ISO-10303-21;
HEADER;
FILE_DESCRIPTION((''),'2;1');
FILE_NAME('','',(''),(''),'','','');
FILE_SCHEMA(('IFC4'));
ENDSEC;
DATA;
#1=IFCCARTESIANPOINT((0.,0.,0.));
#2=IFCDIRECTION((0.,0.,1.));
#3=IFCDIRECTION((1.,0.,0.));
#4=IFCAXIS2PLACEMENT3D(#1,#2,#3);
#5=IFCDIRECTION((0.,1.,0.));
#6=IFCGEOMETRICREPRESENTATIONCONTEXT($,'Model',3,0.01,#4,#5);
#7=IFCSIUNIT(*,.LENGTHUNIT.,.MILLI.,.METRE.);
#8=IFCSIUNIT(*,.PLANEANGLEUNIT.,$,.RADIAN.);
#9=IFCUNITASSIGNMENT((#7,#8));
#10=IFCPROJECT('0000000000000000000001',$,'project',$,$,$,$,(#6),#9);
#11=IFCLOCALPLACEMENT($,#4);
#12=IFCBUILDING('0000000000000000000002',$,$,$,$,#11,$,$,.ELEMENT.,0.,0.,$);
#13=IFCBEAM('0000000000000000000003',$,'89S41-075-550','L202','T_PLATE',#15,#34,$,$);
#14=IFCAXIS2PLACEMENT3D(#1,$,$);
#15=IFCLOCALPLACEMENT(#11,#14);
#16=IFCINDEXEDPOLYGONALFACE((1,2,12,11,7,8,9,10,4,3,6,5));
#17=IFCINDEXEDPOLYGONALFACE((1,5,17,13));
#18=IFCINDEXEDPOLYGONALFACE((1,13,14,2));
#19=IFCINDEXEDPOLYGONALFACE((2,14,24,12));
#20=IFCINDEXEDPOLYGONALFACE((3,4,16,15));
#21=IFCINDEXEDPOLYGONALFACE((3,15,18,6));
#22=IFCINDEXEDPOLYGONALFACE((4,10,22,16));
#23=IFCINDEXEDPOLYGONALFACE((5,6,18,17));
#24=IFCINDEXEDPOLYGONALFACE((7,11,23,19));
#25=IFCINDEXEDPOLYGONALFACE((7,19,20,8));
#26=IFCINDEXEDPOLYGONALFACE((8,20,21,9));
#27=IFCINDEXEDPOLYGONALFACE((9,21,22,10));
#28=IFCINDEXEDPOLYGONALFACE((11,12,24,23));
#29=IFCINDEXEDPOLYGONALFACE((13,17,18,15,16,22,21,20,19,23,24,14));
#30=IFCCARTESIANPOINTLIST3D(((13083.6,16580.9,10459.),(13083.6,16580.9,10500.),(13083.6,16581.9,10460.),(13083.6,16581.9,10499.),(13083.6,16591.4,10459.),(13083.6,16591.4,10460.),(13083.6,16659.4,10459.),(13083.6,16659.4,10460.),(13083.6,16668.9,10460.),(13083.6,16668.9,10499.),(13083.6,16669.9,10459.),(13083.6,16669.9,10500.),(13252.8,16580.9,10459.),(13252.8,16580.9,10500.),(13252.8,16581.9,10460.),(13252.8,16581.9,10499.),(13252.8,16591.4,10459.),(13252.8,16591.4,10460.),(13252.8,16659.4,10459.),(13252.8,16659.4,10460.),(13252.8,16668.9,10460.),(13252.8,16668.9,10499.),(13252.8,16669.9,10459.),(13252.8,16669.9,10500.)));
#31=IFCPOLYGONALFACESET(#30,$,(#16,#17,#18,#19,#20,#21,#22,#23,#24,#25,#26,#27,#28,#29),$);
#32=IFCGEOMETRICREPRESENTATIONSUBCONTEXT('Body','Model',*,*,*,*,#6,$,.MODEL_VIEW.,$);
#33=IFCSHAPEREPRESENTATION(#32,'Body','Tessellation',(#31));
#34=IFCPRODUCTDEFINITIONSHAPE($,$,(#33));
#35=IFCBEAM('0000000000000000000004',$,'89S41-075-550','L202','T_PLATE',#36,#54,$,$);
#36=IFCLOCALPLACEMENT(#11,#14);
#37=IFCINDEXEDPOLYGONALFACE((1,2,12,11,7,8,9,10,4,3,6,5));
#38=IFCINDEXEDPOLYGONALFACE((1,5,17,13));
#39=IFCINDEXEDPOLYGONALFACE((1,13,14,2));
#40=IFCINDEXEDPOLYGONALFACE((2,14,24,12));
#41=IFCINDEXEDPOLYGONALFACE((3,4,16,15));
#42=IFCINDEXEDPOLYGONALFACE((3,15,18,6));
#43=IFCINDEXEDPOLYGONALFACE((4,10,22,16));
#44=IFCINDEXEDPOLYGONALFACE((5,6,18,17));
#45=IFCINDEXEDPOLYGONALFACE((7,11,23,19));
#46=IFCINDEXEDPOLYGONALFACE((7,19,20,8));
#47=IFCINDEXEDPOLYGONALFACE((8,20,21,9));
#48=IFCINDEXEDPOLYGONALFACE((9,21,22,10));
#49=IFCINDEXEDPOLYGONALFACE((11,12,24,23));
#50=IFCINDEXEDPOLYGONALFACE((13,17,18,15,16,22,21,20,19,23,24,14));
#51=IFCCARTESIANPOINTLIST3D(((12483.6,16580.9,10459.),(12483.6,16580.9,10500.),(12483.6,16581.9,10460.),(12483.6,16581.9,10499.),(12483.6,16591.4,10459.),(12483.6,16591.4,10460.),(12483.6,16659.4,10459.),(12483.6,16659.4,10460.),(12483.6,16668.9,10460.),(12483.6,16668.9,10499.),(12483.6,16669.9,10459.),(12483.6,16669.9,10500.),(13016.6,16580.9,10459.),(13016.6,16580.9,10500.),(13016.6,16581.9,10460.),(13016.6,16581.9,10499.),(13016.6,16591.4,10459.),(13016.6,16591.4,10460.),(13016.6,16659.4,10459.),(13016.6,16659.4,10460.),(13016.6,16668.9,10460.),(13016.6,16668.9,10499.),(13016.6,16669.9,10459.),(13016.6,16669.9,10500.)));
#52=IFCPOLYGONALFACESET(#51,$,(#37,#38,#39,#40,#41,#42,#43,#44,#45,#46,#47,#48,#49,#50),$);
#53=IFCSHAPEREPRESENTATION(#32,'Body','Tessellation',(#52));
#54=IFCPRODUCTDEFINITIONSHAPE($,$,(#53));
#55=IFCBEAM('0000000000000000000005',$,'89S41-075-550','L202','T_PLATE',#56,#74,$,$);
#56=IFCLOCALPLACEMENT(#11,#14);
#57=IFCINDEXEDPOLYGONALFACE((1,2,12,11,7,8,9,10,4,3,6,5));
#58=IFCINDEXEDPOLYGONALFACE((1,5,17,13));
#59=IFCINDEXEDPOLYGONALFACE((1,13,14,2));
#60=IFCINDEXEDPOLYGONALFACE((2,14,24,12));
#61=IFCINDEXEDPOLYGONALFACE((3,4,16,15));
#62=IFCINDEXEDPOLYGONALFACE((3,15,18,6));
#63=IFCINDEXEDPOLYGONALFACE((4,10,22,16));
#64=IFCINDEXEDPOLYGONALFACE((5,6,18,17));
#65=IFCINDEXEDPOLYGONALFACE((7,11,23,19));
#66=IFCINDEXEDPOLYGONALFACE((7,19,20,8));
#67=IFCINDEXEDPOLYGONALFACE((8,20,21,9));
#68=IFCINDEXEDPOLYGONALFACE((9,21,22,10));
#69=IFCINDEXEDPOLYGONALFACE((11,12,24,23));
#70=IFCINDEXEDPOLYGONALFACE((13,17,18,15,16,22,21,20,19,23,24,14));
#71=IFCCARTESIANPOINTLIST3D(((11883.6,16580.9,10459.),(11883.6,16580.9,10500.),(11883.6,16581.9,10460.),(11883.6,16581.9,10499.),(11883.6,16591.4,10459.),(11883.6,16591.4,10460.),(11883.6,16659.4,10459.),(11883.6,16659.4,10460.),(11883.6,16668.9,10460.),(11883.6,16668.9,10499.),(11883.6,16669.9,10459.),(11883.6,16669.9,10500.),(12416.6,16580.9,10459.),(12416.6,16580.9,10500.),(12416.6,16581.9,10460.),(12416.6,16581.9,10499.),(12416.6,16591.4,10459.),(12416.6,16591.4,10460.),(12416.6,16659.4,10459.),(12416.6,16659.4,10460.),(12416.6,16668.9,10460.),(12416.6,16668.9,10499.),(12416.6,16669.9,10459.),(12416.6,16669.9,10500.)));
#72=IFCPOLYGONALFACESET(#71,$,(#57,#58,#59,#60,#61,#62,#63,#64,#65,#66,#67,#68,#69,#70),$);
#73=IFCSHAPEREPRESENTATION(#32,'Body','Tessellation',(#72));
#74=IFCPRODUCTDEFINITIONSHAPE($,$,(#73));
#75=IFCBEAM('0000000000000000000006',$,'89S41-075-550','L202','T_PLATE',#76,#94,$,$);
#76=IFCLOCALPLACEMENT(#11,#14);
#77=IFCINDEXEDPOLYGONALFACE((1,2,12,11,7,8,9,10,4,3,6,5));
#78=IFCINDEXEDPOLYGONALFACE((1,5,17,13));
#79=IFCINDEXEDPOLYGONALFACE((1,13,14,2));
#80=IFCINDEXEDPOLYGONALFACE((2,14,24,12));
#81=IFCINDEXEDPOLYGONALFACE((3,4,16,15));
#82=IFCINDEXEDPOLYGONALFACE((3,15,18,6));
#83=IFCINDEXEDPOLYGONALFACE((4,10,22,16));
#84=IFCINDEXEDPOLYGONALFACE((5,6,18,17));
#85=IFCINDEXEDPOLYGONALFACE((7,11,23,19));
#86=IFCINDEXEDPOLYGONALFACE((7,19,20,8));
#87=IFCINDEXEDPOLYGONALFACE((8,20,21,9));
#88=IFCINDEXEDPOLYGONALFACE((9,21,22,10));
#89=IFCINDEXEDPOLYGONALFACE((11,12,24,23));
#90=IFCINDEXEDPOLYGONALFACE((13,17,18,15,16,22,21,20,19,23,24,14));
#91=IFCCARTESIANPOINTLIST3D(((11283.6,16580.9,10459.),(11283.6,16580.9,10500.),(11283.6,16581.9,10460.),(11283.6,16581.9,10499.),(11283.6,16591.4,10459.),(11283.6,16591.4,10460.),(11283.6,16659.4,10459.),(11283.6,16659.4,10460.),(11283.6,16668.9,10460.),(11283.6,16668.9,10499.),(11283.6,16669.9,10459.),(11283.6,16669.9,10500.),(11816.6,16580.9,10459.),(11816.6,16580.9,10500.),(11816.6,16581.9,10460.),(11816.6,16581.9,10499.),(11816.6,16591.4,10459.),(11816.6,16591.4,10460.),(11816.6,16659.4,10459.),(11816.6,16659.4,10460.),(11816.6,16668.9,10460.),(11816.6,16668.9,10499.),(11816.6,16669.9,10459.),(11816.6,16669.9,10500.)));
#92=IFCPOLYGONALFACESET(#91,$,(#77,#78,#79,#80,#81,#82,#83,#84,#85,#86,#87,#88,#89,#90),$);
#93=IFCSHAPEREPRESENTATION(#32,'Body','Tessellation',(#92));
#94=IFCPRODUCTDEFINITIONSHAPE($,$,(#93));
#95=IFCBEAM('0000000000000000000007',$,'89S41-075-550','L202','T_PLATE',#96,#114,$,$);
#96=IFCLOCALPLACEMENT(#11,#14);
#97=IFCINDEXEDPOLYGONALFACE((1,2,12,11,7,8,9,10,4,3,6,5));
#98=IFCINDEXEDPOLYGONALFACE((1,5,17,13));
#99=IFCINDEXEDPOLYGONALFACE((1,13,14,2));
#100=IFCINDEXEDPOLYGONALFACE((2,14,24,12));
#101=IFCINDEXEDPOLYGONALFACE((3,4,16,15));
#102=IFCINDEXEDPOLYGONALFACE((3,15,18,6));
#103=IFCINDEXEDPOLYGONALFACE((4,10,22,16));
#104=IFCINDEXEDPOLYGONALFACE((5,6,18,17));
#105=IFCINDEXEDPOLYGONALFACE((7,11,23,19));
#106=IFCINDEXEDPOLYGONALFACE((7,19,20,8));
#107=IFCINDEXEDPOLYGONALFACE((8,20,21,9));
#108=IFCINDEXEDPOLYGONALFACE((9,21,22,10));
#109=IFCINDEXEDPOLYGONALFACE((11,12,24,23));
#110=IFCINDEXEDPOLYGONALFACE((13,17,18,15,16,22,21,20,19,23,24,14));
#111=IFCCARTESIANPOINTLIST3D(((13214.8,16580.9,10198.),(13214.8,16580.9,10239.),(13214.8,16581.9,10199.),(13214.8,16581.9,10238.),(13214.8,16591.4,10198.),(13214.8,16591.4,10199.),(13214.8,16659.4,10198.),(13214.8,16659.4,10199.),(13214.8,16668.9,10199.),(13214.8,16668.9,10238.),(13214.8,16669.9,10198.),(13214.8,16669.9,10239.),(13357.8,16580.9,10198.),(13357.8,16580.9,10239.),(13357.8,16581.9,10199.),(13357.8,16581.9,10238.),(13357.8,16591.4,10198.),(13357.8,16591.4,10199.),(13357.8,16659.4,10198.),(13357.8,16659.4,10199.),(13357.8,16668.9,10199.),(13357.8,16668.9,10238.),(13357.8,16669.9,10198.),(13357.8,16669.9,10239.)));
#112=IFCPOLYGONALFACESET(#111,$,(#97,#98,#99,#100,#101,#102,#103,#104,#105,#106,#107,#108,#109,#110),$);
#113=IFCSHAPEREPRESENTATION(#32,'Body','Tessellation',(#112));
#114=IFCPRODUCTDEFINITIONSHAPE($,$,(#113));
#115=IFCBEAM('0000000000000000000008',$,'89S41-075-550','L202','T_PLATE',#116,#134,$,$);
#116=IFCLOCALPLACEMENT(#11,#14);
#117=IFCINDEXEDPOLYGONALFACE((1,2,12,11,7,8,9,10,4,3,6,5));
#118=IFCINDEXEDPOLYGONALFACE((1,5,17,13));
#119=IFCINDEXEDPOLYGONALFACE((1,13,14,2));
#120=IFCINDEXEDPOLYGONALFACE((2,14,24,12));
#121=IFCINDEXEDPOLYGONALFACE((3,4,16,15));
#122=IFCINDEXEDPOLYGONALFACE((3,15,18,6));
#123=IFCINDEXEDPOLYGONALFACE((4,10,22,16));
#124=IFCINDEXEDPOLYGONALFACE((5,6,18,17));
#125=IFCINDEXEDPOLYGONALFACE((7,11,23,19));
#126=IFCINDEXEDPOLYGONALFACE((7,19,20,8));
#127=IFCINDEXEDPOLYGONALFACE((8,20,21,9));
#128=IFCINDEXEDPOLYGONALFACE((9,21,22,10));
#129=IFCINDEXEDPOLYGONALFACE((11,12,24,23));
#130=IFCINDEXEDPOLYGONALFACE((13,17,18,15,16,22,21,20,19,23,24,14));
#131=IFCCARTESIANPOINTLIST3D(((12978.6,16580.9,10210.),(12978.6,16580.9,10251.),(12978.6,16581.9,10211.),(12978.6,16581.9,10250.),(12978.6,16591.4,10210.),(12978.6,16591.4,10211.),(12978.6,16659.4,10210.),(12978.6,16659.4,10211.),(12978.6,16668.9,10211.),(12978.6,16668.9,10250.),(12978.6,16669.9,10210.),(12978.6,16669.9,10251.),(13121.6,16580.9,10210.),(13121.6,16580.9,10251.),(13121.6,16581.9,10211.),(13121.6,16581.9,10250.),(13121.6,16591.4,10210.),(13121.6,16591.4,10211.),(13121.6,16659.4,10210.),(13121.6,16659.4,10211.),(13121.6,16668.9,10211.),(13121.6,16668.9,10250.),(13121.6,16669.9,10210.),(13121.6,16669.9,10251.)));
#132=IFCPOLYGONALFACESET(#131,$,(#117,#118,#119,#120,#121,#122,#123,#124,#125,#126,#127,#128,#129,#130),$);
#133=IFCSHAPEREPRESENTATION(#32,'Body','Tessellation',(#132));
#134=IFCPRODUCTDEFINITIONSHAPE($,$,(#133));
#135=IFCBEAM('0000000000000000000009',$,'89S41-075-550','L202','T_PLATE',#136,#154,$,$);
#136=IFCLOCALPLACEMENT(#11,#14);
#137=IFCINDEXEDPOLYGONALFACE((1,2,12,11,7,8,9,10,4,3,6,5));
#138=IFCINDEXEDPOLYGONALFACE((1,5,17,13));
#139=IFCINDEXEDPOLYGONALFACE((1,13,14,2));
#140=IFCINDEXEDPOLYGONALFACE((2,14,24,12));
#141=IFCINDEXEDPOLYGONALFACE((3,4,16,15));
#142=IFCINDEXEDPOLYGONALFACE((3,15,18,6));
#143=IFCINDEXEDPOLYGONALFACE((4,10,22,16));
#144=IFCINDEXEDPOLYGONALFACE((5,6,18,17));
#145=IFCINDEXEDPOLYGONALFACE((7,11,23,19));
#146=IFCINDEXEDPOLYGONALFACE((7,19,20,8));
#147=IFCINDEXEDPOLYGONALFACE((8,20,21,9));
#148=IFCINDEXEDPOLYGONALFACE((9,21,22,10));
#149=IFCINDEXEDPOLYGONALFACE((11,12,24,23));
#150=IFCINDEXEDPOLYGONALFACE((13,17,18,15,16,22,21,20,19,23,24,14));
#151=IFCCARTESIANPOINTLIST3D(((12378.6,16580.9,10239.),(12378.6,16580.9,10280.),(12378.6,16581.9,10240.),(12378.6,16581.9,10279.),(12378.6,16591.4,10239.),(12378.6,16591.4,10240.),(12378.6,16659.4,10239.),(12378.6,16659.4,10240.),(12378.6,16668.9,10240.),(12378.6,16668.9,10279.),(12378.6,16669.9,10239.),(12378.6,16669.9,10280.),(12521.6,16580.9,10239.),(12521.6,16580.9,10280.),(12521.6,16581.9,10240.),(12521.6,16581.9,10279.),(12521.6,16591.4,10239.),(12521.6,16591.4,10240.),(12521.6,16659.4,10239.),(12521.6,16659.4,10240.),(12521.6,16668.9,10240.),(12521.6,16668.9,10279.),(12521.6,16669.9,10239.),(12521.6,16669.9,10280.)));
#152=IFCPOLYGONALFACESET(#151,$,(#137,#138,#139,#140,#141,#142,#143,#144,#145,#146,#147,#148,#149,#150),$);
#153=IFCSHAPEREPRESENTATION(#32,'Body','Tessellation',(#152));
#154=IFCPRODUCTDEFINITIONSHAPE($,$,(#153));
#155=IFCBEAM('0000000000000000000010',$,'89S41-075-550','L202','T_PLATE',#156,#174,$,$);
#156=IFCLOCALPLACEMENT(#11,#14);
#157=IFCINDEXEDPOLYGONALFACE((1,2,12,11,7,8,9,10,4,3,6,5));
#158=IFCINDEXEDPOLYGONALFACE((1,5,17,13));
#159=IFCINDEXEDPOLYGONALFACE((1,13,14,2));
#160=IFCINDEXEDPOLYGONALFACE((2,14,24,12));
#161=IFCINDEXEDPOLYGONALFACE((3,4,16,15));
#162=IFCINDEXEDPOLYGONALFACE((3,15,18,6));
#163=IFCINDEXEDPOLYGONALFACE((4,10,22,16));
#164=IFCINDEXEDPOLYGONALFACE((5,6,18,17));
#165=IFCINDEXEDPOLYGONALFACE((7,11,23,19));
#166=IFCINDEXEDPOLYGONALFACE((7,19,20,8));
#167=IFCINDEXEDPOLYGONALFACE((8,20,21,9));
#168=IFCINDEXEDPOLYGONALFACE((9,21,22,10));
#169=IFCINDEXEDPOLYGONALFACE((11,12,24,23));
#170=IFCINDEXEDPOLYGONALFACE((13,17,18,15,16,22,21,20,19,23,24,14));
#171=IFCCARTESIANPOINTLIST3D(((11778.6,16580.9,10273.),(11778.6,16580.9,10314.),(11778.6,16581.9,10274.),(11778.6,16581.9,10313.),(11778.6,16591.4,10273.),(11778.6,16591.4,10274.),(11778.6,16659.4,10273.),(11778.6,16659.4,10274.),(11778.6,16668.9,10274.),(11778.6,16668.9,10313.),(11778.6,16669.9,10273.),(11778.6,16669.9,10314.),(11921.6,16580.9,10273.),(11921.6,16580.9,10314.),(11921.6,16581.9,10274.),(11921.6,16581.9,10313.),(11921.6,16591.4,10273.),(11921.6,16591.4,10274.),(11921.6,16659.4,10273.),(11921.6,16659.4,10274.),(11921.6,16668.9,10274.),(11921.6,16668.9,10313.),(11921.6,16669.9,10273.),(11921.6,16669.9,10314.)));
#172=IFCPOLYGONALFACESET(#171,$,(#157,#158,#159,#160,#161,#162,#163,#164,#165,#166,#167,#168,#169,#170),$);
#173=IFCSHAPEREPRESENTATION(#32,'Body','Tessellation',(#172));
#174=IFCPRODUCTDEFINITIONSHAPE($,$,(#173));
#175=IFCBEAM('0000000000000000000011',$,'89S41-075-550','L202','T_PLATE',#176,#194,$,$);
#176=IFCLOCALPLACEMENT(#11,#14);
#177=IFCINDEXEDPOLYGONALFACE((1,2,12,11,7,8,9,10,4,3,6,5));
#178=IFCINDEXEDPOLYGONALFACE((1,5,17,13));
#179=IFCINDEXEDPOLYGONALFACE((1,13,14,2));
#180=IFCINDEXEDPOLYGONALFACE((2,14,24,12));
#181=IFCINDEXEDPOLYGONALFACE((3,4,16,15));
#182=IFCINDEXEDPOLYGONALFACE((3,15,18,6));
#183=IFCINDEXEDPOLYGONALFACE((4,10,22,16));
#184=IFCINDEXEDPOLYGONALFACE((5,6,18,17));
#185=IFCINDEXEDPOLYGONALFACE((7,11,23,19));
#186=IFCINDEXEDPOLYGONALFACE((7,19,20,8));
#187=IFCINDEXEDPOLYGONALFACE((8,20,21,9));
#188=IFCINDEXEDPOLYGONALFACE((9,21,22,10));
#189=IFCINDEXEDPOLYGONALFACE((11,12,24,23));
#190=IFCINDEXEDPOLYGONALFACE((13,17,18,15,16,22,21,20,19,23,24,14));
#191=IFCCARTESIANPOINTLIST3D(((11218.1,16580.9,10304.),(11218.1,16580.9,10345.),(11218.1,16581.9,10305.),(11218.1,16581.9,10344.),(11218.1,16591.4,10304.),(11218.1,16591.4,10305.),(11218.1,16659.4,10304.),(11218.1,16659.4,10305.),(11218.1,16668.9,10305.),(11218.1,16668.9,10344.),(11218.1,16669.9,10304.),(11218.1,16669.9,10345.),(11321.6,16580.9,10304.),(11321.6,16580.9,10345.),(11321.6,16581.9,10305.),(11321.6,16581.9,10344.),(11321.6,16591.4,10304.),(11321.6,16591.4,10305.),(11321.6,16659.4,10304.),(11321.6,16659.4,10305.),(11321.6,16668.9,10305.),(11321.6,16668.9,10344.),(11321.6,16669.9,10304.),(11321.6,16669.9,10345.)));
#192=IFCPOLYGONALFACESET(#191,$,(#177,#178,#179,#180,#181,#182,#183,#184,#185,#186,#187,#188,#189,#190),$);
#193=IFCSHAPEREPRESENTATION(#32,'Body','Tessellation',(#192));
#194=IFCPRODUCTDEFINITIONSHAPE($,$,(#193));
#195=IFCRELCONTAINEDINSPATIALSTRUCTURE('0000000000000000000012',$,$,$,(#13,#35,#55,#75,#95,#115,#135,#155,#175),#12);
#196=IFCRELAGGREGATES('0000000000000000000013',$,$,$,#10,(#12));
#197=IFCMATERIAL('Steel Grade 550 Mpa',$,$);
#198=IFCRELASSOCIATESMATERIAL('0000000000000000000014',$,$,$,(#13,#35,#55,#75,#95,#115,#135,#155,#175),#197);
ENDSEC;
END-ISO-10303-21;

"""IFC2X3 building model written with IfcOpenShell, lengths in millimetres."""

from ifc_helpers import new_model, si_unit, direction, frame, origin, origin_with_axes, origin_2d_with_axis, place, context, subcontext, project, spatial, c_section, extrude, source, transform, mapped, material, element, save


model = new_model("IFC2X3")

# Units and contexts
model_context = context("Model", 3, precision=0.01, world=origin_with_axes(), true_north=direction((0.0, 1.0, 0.0)))
body_context = subcontext(model_context, "Body", "Model", "MODEL_VIEW")
ifc_project = project(units=[si_unit("LENGTHUNIT", "METRE", prefix="MILLI"), si_unit("PLANEANGLEUNIT", "RADIAN")], contexts=[model_context])

# Building
building_placement = place(None, origin_with_axes())
building = spatial("IfcBuilding", under=ifc_project, at=building_placement, CompositionType="ELEMENT", ElevationOfRefHeight=0.0, ElevationOfTerrain=0.0)

# Shared definitions
ifc_material_1 = material(Name="Steel Grade 550 Mpa")

# Beams
shared_shape_1 = source(origin(), body_context, "Body", "SweptSolid", [
    extrude(c_section(Depth=89.0, Width=41.0, WallThickness=1.0, Girth=10.5, at=origin_2d_with_axis()), origin_with_axes(), (0.0, 0.0, 1.0), 169.2),
])
beam_1_placement = place(None, frame((13083.6, 16625.4, 10479.5), z_axis=(1.0, 0.0, 0.0), x_axis=(0.0, 0.0, -1.0)))
element("IfcBeam", 1, at=beam_1_placement, inside=building, material=ifc_material_1, Name="89S41-075-550", Description="L202", ObjectType="T_PLATE", context=body_context, shape_type="MappedRepresentation", body=[
    mapped(shared_shape_1, transform((0.0, 0.0, 0.0), scale=1.0)),
])
shared_shape_2 = source(origin(), body_context, "Body", "SweptSolid", [
    extrude(c_section(Depth=89.0, Width=41.0, WallThickness=1.0, Girth=10.5, at=origin_2d_with_axis()), origin_with_axes(), (0.0, 0.0, 1.0), 533.0),
])
beam_2_placement = place(None, frame((12483.6, 16625.4, 10479.5), z_axis=(1.0, 0.0, 0.0), x_axis=(0.0, 0.0, -1.0)))
element("IfcBeam", 2, at=beam_2_placement, inside=building, material=ifc_material_1, Name="89S41-075-550", Description="L202", ObjectType="T_PLATE", context=body_context, shape_type="MappedRepresentation", body=[
    mapped(shared_shape_2, transform((0.0, 0.0, 0.0), scale=1.0)),
])
shared_shape_3 = source(origin(), body_context, "Body", "SweptSolid", [
    extrude(c_section(Depth=89.0, Width=41.0, WallThickness=1.0, Girth=10.5, at=origin_2d_with_axis()), origin_with_axes(), (0.0, 0.0, 1.0), 533.0),
])
beam_3_placement = place(None, frame((11883.6, 16625.4, 10479.5), z_axis=(1.0, 0.0, 0.0), x_axis=(0.0, 0.0, -1.0)))
element("IfcBeam", 3, at=beam_3_placement, inside=building, material=ifc_material_1, Name="89S41-075-550", Description="L202", ObjectType="T_PLATE", context=body_context, shape_type="MappedRepresentation", body=[
    mapped(shared_shape_3, transform((0.0, 0.0, 0.0), scale=1.0)),
])
shared_shape_4 = source(origin(), body_context, "Body", "SweptSolid", [
    extrude(c_section(Depth=89.0, Width=41.0, WallThickness=1.0, Girth=10.5, at=origin_2d_with_axis()), origin_with_axes(), (0.0, 0.0, 1.0), 533.0),
])
beam_4_placement = place(None, frame((11283.6, 16625.4, 10479.5), z_axis=(1.0, 0.0, 0.0), x_axis=(0.0, 0.0, -1.0)))
element("IfcBeam", 4, at=beam_4_placement, inside=building, material=ifc_material_1, Name="89S41-075-550", Description="L202", ObjectType="T_PLATE", context=body_context, shape_type="MappedRepresentation", body=[
    mapped(shared_shape_4, transform((0.0, 0.0, 0.0), scale=1.0)),
])
shared_shape_5 = source(origin(), body_context, "Body", "SweptSolid", [
    extrude(c_section(Depth=89.0, Width=41.0, WallThickness=1.0, Girth=10.5, at=origin_2d_with_axis()), origin_with_axes(), (0.0, 0.0, 1.0), 143.0),
])
beam_5_placement = place(None, frame((13214.8, 16625.4, 10218.5), z_axis=(1.0, 0.0, 0.0), x_axis=(0.0, 0.0, -1.0)))
element("IfcBeam", 5, at=beam_5_placement, inside=building, material=ifc_material_1, Name="89S41-075-550", Description="L202", ObjectType="T_PLATE", context=body_context, shape_type="MappedRepresentation", body=[
    mapped(shared_shape_5, transform((0.0, 0.0, 0.0), scale=1.0)),
])
shared_shape_6 = source(origin(), body_context, "Body", "SweptSolid", [
    extrude(c_section(Depth=89.0, Width=41.0, WallThickness=1.0, Girth=10.5, at=origin_2d_with_axis()), origin_with_axes(), (0.0, 0.0, 1.0), 143.0),
])
beam_6_placement = place(None, frame((12978.6, 16625.4, 10230.5), z_axis=(1.0, 0.0, 0.0), x_axis=(0.0, 0.0, -1.0)))
element("IfcBeam", 6, at=beam_6_placement, inside=building, material=ifc_material_1, Name="89S41-075-550", Description="L202", ObjectType="T_PLATE", context=body_context, shape_type="MappedRepresentation", body=[
    mapped(shared_shape_6, transform((0.0, 0.0, 0.0), scale=1.0)),
])
shared_shape_7 = source(origin(), body_context, "Body", "SweptSolid", [
    extrude(c_section(Depth=89.0, Width=41.0, WallThickness=1.0, Girth=10.5, at=origin_2d_with_axis()), origin_with_axes(), (0.0, 0.0, 1.0), 143.0),
])
beam_7_placement = place(None, frame((12378.6, 16625.4, 10259.5), z_axis=(1.0, 0.0, 0.0), x_axis=(0.0, 0.0, -1.0)))
element("IfcBeam", 7, at=beam_7_placement, inside=building, material=ifc_material_1, Name="89S41-075-550", Description="L202", ObjectType="T_PLATE", context=body_context, shape_type="MappedRepresentation", body=[
    mapped(shared_shape_7, transform((0.0, 0.0, 0.0), scale=1.0)),
])
shared_shape_8 = source(origin(), body_context, "Body", "SweptSolid", [
    extrude(c_section(Depth=89.0, Width=41.0, WallThickness=1.0, Girth=10.5, at=origin_2d_with_axis()), origin_with_axes(), (0.0, 0.0, 1.0), 143.0),
])
beam_8_placement = place(None, frame((11778.6, 16625.4, 10293.5), z_axis=(1.0, 0.0, 0.0), x_axis=(0.0, 0.0, -1.0)))
element("IfcBeam", 8, at=beam_8_placement, inside=building, material=ifc_material_1, Name="89S41-075-550", Description="L202", ObjectType="T_PLATE", context=body_context, shape_type="MappedRepresentation", body=[
    mapped(shared_shape_8, transform((0.0, 0.0, 0.0), scale=1.0)),
])
shared_shape_9 = source(origin(), body_context, "Body", "SweptSolid", [
    extrude(c_section(Depth=89.0, Width=41.0, WallThickness=1.0, Girth=10.5, at=origin_2d_with_axis()), origin_with_axes(), (0.0, 0.0, 1.0), 103.5),
])
beam_9_placement = place(None, frame((11218.1, 16625.4, 10324.5), z_axis=(1.0, 0.0, 0.0), x_axis=(0.0, 0.0, -1.0)))
element("IfcBeam", 9, at=beam_9_placement, inside=building, material=ifc_material_1, Name="89S41-075-550", Description="L202", ObjectType="T_PLATE", context=body_context, shape_type="MappedRepresentation", body=[
    mapped(shared_shape_9, transform((0.0, 0.0, 0.0), scale=1.0)),
])

save(model, "model.ifc")
